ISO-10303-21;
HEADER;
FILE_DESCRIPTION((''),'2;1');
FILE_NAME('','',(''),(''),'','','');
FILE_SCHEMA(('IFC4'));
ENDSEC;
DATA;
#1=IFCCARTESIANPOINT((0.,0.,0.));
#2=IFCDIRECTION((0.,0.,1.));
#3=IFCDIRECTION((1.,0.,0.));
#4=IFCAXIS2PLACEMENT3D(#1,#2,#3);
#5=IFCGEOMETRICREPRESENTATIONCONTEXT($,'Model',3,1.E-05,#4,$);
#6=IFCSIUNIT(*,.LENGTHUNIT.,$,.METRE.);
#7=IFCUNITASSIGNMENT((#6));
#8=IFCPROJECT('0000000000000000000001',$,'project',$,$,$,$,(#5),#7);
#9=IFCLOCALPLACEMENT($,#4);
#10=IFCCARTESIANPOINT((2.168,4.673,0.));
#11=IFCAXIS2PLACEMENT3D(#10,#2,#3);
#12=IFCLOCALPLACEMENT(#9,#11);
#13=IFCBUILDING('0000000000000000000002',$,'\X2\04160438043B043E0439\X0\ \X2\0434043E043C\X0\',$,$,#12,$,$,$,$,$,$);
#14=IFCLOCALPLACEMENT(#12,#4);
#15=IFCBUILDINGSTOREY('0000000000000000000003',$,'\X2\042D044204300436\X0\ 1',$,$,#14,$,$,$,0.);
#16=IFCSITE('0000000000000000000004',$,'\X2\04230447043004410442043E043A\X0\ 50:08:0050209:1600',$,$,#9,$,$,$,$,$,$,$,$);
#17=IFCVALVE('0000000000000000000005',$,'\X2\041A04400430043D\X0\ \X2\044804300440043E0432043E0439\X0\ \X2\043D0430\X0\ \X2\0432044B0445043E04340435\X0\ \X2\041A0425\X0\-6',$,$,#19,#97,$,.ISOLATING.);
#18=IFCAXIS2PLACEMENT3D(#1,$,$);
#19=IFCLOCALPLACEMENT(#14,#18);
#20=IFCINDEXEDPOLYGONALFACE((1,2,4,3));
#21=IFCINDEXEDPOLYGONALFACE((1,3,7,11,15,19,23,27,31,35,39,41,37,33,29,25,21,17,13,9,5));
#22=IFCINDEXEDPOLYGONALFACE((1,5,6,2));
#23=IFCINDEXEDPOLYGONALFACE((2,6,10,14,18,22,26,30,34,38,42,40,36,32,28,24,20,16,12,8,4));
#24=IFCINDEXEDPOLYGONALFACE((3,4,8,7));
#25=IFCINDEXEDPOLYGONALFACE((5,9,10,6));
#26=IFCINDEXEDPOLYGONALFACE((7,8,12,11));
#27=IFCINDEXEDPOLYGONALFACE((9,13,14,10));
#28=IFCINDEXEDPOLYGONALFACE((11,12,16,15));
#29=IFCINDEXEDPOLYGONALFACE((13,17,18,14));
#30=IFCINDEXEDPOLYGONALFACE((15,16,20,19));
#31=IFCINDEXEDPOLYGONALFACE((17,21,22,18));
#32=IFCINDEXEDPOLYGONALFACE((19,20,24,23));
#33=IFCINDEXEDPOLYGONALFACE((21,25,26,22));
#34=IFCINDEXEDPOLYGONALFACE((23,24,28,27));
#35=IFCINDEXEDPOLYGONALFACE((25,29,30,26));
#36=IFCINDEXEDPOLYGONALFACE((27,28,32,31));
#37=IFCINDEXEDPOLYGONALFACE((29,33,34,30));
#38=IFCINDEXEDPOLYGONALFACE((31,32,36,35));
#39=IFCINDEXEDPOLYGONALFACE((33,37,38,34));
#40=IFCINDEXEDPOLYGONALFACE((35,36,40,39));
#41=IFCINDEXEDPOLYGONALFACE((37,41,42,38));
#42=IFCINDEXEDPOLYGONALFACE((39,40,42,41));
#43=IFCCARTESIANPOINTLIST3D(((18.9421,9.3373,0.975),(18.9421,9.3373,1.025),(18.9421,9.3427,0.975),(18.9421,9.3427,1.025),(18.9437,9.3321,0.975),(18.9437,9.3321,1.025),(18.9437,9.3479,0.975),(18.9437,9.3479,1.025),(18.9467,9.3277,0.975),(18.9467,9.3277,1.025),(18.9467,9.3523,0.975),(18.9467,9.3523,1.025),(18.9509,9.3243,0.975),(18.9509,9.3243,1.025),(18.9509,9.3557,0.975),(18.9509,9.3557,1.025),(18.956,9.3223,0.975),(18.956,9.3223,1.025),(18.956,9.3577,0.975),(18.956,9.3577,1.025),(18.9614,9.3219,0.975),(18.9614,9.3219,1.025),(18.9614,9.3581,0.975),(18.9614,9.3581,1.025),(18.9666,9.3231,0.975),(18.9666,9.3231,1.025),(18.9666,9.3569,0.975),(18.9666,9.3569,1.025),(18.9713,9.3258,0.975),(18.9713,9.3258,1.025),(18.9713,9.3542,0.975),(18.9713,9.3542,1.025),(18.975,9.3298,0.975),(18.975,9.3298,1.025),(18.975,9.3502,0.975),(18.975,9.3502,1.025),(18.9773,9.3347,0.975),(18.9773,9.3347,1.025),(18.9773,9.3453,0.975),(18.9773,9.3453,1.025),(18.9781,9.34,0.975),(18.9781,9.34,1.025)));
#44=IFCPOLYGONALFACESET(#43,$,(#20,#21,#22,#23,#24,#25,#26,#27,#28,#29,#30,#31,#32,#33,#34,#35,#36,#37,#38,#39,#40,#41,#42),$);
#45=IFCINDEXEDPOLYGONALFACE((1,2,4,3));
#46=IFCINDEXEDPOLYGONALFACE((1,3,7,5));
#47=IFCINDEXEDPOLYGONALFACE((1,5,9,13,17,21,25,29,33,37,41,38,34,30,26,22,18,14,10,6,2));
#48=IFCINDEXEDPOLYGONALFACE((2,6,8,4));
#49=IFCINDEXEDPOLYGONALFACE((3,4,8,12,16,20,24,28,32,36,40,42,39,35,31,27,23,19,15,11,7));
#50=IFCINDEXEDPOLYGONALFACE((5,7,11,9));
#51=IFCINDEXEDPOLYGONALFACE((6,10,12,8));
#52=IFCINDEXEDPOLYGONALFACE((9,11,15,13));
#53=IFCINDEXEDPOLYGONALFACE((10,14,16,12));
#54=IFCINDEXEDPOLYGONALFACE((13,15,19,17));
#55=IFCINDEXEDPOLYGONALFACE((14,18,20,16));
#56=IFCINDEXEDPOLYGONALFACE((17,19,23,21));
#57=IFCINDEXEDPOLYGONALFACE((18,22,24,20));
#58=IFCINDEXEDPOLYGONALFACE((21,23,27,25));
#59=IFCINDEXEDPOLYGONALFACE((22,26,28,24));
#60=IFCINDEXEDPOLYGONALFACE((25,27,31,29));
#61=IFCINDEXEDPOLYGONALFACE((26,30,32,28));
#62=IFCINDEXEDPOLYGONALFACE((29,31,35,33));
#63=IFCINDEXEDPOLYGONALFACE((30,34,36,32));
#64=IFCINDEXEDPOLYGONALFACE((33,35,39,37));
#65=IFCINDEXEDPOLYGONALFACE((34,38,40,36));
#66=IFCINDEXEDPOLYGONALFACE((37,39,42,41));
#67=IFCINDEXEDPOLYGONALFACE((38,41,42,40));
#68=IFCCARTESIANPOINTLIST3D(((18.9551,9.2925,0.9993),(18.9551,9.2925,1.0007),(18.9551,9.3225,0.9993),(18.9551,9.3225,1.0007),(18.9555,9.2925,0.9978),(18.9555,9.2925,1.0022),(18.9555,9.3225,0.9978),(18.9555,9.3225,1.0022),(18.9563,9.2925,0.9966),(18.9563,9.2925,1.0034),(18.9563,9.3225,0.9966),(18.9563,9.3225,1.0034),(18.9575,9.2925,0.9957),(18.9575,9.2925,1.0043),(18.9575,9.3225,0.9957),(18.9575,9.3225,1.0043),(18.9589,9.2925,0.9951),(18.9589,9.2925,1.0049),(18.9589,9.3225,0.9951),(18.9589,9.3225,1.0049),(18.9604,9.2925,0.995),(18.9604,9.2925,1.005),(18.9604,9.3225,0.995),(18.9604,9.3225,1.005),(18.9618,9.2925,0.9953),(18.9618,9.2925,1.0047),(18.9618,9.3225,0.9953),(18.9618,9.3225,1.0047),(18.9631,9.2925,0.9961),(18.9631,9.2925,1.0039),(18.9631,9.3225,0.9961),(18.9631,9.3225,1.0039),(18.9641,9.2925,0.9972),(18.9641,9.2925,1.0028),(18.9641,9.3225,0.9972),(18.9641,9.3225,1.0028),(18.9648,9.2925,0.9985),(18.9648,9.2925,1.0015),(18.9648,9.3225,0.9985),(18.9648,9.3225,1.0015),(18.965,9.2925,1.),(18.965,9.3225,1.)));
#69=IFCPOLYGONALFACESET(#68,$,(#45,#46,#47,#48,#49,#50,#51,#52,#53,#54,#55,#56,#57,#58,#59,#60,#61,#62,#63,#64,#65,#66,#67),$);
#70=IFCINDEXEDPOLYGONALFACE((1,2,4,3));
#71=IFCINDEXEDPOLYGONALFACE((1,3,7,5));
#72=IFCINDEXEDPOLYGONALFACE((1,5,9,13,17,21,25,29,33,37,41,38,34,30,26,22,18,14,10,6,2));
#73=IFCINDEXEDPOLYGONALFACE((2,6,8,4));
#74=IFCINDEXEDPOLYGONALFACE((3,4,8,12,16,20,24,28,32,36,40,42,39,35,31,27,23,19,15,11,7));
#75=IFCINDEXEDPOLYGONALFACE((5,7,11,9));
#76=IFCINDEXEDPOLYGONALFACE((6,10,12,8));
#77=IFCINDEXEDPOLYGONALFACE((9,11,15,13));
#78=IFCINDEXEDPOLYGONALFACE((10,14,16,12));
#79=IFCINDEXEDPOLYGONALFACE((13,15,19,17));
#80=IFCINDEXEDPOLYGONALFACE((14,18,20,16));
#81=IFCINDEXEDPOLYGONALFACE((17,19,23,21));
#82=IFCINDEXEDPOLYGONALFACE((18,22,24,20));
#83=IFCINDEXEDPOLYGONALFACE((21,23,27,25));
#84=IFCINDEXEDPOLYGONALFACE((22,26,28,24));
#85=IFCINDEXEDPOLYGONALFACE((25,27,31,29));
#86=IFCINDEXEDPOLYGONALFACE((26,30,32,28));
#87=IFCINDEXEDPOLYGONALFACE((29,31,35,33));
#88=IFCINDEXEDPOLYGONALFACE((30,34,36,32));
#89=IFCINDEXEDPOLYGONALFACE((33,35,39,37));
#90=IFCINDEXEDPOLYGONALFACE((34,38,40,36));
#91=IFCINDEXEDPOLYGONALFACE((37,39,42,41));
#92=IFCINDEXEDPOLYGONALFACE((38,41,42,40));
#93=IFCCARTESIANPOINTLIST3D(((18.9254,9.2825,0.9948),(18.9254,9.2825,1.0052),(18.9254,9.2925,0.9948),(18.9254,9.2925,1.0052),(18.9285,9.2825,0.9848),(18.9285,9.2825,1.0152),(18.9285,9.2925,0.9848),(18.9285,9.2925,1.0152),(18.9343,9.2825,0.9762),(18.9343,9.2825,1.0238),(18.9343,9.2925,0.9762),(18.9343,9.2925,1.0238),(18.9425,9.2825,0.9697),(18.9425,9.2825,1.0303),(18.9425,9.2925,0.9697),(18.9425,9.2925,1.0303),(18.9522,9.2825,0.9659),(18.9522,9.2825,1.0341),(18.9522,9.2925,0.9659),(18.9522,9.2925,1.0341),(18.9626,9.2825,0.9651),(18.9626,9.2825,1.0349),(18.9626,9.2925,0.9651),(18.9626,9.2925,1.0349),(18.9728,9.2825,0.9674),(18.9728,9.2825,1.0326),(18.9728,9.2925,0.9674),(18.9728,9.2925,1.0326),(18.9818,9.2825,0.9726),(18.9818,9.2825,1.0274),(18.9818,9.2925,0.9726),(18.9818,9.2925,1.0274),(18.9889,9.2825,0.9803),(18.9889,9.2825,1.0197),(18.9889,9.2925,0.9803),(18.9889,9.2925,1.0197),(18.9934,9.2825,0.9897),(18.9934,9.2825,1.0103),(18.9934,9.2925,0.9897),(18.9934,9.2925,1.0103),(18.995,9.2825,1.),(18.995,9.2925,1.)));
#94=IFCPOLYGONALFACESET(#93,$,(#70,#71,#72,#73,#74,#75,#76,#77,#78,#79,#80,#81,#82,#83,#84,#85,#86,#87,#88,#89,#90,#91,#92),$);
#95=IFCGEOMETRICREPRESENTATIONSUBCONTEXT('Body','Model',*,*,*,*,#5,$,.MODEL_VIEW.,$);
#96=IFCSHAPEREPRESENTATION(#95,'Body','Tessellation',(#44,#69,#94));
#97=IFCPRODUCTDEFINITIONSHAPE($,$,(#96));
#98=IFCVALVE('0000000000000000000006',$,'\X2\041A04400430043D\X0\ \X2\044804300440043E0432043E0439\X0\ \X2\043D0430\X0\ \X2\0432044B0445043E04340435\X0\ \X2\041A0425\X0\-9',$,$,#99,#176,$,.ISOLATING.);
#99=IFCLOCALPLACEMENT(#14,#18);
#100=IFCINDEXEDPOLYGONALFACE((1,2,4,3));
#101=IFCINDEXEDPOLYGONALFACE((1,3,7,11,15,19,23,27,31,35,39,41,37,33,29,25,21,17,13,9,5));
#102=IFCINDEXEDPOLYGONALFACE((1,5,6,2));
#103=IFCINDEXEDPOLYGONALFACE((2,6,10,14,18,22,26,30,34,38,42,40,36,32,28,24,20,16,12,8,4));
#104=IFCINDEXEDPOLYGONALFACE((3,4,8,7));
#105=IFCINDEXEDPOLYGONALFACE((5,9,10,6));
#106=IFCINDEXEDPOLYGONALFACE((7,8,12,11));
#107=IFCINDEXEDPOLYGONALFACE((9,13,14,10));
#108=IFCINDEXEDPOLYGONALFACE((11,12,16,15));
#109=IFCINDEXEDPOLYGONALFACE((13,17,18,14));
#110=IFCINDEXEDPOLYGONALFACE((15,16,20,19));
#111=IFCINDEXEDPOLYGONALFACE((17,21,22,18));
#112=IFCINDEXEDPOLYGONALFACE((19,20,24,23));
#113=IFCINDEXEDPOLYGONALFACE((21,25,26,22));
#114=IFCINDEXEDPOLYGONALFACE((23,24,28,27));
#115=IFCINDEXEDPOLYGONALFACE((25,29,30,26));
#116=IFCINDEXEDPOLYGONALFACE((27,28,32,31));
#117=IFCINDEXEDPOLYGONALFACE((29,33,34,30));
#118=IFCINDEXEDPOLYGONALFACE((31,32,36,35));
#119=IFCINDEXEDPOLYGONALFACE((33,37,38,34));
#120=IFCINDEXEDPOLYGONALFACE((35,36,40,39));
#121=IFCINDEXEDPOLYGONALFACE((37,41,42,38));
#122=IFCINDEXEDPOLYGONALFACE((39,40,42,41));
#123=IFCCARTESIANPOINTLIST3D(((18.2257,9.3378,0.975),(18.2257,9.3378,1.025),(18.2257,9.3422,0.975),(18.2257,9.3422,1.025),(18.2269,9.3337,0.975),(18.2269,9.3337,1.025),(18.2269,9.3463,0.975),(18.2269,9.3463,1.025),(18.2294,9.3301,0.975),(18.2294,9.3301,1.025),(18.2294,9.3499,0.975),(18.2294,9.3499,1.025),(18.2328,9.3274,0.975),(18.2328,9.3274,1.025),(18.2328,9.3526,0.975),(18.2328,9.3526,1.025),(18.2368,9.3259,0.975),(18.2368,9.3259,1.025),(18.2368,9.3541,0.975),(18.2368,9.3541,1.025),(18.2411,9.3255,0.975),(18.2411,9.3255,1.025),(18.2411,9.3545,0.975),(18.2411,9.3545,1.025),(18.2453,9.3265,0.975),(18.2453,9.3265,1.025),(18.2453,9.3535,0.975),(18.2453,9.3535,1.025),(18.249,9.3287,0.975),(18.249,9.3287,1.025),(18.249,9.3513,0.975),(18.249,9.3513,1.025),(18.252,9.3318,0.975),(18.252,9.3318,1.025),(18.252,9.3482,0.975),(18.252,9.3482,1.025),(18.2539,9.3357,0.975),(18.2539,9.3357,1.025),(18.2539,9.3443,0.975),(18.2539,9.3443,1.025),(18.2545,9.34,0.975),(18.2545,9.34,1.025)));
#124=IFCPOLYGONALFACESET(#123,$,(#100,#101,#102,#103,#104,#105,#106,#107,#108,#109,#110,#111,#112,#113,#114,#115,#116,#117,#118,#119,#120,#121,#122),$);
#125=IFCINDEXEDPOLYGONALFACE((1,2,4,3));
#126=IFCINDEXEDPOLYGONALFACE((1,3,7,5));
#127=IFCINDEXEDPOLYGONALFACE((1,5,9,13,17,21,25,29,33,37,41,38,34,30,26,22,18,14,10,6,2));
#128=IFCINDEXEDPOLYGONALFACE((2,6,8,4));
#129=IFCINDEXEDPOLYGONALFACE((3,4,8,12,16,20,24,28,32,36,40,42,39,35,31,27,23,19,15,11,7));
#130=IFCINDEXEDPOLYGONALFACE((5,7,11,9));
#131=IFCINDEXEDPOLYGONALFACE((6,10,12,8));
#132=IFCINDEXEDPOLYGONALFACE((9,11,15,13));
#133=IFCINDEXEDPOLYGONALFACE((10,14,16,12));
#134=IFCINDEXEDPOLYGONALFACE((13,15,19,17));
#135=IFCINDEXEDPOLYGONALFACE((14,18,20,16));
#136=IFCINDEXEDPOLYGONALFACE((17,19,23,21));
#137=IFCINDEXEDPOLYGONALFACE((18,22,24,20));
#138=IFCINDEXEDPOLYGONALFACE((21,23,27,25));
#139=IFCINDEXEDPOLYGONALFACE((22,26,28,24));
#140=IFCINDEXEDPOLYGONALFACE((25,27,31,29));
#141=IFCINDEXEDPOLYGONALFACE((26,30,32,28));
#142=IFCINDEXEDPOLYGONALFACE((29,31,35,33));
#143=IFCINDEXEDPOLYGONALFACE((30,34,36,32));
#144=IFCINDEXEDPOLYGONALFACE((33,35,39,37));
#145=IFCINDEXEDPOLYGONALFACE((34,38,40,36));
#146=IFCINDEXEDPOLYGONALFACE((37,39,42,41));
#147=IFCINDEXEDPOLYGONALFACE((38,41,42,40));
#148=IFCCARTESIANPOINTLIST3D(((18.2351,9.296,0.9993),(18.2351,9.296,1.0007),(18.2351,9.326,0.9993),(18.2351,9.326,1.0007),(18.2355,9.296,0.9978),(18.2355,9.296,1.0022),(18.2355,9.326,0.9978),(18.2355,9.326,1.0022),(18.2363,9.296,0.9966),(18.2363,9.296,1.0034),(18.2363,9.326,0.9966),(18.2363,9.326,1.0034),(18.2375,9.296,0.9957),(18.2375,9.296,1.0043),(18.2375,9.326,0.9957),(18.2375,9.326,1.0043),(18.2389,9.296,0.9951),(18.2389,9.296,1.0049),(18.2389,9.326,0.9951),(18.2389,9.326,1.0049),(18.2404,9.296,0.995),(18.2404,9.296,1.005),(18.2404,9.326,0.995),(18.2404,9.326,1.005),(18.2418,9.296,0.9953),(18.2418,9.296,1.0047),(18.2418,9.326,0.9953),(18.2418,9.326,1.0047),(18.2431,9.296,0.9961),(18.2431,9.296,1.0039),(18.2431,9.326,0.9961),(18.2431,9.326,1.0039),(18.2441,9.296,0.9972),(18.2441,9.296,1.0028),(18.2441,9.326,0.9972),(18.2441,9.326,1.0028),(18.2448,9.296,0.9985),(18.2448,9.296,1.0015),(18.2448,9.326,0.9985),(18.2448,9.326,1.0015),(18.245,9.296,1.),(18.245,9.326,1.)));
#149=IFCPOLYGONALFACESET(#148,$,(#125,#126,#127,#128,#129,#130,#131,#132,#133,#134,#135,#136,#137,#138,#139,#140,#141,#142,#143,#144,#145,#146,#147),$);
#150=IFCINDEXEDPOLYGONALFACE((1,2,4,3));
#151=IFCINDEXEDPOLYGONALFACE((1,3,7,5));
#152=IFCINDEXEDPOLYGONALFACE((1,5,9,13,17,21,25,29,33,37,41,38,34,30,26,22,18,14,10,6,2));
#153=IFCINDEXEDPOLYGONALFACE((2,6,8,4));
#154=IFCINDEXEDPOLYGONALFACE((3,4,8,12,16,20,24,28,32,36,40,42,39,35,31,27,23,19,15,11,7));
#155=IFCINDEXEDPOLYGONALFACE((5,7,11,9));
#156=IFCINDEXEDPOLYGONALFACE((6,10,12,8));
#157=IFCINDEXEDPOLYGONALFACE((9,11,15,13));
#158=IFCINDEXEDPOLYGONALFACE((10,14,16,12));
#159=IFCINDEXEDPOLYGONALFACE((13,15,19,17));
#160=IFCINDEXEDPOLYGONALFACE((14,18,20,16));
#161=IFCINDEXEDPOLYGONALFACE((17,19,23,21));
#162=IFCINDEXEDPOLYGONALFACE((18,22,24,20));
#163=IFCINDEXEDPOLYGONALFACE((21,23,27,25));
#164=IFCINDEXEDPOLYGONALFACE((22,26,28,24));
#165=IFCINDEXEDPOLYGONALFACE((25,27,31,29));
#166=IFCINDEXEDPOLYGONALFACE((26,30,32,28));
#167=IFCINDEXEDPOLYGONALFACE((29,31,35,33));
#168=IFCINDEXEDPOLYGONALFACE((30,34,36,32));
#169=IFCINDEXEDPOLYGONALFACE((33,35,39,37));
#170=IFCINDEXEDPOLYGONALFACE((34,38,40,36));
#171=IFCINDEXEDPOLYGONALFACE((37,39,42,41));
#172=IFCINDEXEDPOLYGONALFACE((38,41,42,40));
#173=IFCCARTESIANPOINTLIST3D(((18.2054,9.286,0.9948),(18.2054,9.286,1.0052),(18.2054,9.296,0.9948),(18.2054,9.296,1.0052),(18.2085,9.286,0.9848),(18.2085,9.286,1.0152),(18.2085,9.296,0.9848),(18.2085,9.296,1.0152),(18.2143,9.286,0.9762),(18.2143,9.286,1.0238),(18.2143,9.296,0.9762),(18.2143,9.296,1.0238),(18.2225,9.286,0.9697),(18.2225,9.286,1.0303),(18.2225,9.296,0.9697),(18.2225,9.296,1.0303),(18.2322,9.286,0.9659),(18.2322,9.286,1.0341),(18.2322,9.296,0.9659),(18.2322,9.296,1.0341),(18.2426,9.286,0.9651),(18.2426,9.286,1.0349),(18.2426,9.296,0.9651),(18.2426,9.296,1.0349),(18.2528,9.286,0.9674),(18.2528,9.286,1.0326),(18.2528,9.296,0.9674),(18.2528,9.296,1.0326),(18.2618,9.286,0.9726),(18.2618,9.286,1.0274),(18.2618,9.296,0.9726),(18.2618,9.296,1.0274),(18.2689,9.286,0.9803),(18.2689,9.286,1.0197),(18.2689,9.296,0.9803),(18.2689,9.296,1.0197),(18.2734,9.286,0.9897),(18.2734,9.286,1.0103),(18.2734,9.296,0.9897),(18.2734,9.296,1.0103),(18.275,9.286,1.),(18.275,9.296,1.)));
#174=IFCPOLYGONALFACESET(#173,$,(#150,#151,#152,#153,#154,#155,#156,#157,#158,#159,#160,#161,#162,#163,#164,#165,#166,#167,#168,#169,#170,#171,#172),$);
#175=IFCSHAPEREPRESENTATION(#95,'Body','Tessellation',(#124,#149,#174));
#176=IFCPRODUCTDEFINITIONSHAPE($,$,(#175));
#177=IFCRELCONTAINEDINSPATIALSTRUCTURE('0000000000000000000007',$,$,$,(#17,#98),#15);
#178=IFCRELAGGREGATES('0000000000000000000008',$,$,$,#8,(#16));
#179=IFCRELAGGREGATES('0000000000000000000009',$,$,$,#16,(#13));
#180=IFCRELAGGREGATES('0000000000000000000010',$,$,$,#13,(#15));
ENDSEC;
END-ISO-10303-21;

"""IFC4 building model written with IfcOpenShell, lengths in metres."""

from ifc_helpers import new_model, si_unit, frame, origin_with_axes, origin_2d, place, context, subcontext, project, spatial, circle, extrude, element, save


model = new_model("IFC4")

# Units and contexts
model_context = context("Model", 3, precision=1e-05, world=origin_with_axes())
body_context = subcontext(model_context, "Body", "Model", "MODEL_VIEW")
ifc_project = project(units=[si_unit("LENGTHUNIT", "METRE")], contexts=[model_context])

# Site, building, storey
site_placement = place(None, origin_with_axes())
site = spatial("IfcSite", under=ifc_project, at=site_placement, Name="Участок 50:08:0050209:1600")
building_placement = place(site_placement, frame((2.168, 4.673, 0.0), z_axis=(0.0, 0.0, 1.0), x_axis=(1.0, 0.0, 0.0)))
building = spatial("IfcBuilding", under=site, at=building_placement, Name="Жилой дом")
storey_placement = place(building_placement, origin_with_axes())
storey = spatial("IfcBuildingStorey", under=building, at=storey_placement, Name="Этаж 1", Elevation=0.0)

# Valves
valve_1_placement = place(storey_placement, origin_with_axes())
element("IfcValve", 1, at=valve_1_placement, inside=storey, Name="Кран шаровой на выходе КХ-6", PredefinedType="ISOLATING", context=body_context, shape_type="SweptSolid", body=[
    extrude(circle(Radius=0.0181, at=origin_2d()), frame((18.96, 9.34, 0.975), z_axis=(0.0, 0.0, 1.0), x_axis=(1.0, 0.0, 0.0)), (0.0, 0.0, 1.0), 0.05),
    extrude(circle(Radius=0.005, at=origin_2d()), frame((18.96, 9.3225, 1.0), z_axis=(0.0, -1.0, 0.0), x_axis=(1.0, 0.0, 0.0)), (0.0, 0.0, 1.0), 0.03),
    extrude(circle(Radius=0.035, at=origin_2d()), frame((18.96, 9.2925, 1.0), z_axis=(0.0, -1.0, 0.0), x_axis=(1.0, 0.0, 0.0)), (0.0, 0.0, 1.0), 0.01),
])
valve_2_placement = place(storey_placement, origin_with_axes())
element("IfcValve", 2, at=valve_2_placement, inside=storey, Name="Кран шаровой на выходе КХ-9", PredefinedType="ISOLATING", context=body_context, shape_type="SweptSolid", body=[
    extrude(circle(Radius=0.0145, at=origin_2d()), frame((18.24, 9.34, 0.975), z_axis=(0.0, 0.0, 1.0), x_axis=(1.0, 0.0, 0.0)), (0.0, 0.0, 1.0), 0.05),
    extrude(circle(Radius=0.005, at=origin_2d()), frame((18.24, 9.326, 1.0), z_axis=(0.0, -1.0, 0.0), x_axis=(1.0, 0.0, 0.0)), (0.0, 0.0, 1.0), 0.03),
    extrude(circle(Radius=0.035, at=origin_2d()), frame((18.24, 9.296, 1.0), z_axis=(0.0, -1.0, 0.0), x_axis=(1.0, 0.0, 0.0)), (0.0, 0.0, 1.0), 0.01),
])

save(model, "model.ifc")
